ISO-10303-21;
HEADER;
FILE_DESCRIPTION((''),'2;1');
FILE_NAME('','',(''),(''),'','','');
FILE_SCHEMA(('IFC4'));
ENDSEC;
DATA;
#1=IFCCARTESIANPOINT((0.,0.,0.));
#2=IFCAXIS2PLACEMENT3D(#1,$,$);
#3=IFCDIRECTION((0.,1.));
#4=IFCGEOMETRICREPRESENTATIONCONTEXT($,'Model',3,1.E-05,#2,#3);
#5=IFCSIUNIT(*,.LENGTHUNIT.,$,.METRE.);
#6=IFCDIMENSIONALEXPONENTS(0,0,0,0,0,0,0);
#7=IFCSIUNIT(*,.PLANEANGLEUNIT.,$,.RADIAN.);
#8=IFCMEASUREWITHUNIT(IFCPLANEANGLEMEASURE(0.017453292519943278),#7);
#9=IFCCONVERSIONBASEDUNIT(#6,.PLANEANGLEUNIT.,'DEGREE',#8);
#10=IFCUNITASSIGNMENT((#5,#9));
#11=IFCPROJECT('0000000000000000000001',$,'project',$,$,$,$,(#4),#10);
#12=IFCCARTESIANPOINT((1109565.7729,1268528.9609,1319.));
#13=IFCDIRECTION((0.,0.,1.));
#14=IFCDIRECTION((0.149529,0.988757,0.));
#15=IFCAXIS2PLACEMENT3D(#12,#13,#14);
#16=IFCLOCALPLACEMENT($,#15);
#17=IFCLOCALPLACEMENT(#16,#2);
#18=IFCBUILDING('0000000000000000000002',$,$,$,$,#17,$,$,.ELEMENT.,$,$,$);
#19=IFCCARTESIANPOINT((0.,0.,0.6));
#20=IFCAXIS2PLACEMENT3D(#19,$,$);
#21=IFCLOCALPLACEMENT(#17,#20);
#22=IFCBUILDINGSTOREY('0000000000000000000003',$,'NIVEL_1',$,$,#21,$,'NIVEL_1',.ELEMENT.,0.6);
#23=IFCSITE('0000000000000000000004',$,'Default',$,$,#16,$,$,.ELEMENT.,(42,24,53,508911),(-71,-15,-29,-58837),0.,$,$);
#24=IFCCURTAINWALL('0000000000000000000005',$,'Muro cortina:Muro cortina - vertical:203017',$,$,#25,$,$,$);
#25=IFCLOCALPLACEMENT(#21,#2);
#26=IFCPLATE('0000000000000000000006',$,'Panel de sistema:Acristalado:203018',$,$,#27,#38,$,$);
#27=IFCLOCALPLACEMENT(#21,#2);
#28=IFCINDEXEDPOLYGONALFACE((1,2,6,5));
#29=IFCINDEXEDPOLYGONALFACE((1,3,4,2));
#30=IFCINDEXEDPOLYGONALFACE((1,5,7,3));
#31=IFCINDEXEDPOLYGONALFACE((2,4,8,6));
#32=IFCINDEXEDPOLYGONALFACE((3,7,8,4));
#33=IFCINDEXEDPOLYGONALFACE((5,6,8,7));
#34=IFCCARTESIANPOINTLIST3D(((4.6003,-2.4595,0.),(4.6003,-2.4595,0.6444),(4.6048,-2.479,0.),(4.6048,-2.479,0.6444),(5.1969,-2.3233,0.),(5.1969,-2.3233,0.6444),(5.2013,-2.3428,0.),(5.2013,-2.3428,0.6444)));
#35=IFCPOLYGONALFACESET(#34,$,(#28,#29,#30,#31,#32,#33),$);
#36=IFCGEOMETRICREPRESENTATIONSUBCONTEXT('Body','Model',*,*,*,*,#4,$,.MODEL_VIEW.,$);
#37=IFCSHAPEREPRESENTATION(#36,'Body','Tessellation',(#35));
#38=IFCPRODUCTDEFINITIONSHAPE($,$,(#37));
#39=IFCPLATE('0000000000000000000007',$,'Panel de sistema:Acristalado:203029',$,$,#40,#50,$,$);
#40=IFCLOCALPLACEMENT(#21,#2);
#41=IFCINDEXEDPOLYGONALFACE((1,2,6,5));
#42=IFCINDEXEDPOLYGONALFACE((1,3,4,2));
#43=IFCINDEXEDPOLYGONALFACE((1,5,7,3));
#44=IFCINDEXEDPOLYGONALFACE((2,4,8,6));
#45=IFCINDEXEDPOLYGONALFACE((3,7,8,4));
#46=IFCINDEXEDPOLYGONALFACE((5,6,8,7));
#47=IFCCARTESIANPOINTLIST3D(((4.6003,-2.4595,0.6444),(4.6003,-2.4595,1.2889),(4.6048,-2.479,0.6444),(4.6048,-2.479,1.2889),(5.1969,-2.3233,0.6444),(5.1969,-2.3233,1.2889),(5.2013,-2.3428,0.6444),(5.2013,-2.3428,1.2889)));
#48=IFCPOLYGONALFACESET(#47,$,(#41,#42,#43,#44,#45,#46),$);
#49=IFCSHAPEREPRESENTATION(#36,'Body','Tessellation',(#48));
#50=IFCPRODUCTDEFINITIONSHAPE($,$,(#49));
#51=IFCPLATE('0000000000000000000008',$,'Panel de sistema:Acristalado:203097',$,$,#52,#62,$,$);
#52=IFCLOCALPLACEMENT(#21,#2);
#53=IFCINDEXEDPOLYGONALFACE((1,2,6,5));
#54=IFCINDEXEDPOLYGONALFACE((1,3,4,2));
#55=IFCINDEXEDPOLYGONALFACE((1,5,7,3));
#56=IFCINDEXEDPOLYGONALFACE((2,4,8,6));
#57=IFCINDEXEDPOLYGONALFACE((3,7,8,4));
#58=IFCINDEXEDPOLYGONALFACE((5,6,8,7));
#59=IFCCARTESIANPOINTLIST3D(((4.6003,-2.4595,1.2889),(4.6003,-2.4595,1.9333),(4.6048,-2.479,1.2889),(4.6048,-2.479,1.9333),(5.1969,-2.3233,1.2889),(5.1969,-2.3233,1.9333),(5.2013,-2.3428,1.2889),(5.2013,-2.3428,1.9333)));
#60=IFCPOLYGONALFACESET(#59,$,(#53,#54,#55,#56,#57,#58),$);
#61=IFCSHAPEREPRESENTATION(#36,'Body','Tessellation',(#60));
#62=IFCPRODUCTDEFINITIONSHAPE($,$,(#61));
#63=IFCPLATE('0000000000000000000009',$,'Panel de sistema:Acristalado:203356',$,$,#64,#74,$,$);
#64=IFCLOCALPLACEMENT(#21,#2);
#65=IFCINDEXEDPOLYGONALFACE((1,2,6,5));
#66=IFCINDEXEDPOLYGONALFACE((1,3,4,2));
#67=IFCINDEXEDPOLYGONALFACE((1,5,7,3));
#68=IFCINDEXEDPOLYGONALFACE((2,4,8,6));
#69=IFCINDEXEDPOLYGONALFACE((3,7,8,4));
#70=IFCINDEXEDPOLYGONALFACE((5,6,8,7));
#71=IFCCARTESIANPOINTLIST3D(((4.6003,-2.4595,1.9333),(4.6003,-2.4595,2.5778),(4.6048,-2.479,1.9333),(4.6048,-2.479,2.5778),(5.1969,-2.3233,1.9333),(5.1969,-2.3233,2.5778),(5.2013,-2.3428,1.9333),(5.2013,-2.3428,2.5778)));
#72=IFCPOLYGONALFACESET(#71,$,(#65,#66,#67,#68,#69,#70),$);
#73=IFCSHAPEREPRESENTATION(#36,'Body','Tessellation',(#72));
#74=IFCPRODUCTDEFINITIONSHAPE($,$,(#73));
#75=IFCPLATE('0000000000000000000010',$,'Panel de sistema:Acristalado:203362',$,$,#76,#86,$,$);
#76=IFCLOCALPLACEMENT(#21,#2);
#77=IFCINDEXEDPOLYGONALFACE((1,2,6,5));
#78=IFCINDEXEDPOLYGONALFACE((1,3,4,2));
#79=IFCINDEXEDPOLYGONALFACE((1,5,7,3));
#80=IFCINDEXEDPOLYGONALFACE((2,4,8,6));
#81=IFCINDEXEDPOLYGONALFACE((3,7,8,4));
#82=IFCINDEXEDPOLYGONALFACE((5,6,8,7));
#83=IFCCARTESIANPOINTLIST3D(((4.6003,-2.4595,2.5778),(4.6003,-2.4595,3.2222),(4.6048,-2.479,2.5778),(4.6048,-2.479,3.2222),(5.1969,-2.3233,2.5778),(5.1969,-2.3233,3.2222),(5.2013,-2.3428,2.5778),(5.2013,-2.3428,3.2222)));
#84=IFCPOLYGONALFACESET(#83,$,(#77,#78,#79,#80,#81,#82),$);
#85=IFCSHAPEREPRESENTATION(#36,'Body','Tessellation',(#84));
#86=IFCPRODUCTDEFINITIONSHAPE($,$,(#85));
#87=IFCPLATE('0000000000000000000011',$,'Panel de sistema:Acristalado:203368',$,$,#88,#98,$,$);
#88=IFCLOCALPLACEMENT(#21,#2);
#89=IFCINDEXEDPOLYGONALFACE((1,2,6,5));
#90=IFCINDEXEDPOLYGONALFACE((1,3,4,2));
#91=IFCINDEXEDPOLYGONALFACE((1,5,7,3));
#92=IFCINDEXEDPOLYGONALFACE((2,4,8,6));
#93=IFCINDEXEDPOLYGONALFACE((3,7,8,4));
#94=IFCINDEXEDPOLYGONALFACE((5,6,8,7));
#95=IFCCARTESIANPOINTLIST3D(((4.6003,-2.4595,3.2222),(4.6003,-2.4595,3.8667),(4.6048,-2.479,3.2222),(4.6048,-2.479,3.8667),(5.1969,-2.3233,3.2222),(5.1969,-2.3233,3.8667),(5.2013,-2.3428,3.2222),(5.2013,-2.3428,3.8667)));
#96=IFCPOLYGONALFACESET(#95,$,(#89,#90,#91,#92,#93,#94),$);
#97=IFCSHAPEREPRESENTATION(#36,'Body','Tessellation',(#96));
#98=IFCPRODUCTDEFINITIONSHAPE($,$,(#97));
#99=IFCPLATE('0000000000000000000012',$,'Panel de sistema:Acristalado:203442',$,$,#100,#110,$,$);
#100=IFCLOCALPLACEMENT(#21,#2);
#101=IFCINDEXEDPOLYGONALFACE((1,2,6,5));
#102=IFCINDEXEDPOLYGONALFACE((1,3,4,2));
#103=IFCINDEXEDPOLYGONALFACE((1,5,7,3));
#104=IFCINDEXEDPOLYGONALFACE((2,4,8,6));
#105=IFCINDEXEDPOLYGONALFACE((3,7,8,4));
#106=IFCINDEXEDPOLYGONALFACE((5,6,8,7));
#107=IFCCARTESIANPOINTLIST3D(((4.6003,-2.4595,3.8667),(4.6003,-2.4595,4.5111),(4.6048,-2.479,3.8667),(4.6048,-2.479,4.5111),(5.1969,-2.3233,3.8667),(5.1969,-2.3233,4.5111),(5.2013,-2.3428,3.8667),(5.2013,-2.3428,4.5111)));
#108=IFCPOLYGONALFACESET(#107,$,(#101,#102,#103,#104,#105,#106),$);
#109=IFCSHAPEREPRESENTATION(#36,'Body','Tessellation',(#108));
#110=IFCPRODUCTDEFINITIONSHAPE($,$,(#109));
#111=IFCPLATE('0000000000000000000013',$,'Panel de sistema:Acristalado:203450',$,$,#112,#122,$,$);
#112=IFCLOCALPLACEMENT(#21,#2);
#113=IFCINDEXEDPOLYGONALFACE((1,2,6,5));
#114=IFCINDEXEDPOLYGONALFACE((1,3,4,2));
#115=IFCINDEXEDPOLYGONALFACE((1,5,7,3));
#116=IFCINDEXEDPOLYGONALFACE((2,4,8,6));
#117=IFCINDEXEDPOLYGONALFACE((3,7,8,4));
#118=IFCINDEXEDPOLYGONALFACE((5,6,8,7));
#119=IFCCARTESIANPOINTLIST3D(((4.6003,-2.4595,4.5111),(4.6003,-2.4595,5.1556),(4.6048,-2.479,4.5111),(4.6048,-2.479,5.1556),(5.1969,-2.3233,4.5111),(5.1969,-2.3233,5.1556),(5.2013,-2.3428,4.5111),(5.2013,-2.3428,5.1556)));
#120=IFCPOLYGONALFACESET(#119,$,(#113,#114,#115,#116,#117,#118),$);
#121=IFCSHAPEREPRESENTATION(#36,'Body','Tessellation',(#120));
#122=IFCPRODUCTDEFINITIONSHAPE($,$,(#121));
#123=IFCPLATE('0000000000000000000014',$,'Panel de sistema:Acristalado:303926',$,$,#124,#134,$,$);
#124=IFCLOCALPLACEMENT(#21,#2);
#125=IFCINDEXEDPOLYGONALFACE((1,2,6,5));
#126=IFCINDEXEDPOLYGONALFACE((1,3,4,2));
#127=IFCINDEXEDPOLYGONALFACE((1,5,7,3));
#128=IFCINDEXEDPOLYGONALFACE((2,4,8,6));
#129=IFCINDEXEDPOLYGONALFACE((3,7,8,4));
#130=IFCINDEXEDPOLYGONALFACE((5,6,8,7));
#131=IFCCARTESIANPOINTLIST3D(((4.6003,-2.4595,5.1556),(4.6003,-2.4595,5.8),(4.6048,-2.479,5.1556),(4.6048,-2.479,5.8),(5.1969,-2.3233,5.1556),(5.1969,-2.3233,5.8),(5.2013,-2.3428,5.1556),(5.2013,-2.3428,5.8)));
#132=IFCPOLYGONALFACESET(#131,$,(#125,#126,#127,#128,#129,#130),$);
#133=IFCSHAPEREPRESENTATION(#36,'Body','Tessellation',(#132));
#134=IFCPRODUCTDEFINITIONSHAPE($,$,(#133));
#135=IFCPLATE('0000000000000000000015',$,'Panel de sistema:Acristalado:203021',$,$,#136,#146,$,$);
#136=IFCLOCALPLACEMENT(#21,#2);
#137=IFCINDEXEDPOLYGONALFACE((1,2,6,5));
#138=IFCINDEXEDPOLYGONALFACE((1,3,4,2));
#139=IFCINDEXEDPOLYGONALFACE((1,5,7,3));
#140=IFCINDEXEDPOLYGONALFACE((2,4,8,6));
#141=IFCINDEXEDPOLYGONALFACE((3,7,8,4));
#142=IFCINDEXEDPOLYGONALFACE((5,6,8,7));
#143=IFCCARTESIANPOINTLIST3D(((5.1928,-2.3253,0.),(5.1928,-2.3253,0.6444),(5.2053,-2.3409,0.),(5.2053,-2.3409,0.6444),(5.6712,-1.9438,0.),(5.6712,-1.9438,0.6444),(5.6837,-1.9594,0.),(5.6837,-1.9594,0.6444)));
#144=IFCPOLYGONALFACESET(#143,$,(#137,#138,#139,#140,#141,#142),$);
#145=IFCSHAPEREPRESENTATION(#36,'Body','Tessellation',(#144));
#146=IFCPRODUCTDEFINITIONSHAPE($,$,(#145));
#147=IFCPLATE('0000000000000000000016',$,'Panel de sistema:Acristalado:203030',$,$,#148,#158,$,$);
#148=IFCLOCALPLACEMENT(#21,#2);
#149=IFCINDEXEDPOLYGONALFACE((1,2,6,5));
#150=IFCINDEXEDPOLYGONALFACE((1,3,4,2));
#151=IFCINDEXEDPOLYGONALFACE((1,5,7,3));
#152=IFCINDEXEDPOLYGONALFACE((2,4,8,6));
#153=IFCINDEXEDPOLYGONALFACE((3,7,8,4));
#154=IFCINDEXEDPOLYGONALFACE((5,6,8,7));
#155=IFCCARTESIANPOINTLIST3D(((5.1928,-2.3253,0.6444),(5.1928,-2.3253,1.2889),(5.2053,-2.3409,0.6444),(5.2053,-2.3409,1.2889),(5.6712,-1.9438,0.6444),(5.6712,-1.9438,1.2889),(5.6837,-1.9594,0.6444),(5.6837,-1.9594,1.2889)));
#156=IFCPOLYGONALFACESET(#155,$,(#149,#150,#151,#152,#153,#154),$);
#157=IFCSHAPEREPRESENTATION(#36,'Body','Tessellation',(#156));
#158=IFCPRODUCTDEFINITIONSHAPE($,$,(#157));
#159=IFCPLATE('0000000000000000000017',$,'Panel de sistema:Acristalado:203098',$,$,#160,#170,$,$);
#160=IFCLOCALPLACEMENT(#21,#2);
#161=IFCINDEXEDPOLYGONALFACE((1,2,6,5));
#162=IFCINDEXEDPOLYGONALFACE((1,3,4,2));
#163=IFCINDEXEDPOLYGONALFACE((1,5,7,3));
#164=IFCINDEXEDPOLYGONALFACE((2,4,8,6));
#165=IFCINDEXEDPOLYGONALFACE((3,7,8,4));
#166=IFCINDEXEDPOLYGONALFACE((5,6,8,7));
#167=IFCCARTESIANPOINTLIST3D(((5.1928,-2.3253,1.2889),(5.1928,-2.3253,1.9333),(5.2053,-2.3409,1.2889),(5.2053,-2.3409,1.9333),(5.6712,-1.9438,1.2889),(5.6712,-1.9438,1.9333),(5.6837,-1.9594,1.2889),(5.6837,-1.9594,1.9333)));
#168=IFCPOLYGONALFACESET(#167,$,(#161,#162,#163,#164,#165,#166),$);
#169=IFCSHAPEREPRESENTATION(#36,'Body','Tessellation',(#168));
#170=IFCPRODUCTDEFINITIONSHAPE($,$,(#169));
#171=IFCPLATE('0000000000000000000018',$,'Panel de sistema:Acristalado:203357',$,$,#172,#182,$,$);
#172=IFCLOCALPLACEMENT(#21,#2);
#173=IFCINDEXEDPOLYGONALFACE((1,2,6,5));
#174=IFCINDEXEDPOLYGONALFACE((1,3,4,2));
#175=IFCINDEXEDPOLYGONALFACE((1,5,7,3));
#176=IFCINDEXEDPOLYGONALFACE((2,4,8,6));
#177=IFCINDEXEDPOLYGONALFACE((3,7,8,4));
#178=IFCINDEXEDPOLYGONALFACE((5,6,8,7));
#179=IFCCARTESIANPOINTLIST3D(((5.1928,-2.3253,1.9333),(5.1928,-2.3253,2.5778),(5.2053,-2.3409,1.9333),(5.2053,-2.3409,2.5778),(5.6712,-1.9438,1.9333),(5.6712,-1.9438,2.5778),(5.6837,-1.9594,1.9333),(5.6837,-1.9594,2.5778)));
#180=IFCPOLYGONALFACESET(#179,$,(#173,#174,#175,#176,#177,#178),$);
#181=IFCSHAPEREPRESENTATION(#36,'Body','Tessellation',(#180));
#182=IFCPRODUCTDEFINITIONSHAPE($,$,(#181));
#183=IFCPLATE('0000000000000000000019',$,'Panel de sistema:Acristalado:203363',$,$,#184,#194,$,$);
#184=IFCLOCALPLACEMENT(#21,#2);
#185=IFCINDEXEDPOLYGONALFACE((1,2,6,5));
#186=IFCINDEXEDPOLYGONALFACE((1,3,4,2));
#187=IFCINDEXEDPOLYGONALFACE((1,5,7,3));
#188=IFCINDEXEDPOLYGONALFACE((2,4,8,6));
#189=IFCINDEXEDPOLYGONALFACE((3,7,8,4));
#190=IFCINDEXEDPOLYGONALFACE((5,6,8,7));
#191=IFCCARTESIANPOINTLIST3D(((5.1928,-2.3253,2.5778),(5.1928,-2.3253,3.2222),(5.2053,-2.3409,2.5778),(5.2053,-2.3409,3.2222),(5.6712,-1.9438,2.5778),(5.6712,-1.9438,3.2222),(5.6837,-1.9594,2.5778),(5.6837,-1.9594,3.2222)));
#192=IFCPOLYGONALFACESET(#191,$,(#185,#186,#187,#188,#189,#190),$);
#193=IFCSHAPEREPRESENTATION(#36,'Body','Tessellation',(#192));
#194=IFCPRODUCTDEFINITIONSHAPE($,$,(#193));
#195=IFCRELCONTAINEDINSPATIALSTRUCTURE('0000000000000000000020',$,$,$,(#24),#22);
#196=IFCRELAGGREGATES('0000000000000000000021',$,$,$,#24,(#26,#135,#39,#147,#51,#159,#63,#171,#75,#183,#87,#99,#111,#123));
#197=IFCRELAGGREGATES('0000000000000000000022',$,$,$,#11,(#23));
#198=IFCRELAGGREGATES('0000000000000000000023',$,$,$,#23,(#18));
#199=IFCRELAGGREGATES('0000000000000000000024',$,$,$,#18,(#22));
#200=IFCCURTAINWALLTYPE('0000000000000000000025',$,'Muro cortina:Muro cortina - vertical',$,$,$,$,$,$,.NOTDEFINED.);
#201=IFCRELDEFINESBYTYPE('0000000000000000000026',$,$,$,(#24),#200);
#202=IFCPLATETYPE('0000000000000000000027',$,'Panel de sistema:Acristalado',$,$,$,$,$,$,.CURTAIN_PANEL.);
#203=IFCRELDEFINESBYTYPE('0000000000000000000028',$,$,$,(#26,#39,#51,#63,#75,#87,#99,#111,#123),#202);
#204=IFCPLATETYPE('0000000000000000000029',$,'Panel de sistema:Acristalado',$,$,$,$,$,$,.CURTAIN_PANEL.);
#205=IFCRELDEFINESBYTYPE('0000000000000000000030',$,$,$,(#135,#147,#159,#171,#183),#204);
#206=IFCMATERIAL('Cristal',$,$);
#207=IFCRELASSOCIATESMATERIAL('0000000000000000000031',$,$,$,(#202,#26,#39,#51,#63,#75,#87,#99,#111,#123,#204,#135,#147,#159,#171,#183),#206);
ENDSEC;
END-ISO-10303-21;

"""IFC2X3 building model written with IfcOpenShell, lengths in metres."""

from ifc_helpers import new_model, entity, si_unit, converted_unit, direction, frame, frame_2d, origin, place, context, subcontext, project, spatial, rectangle, extrude, source, transform, mapped, material, type_object, type_shapes, element, aggregate, save


model = new_model("IFC2X3")

# Units and contexts
model_context = context("Model", 3, precision=1e-05, world=origin(), true_north=direction((0.0, 1.0)))
body_context = subcontext(model_context, "Body", "Model", "MODEL_VIEW")
ifc_project = project(units=[si_unit("LENGTHUNIT", "METRE"), converted_unit("PLANEANGLEUNIT", "DEGREE", entity("IfcPlaneAngleMeasure", 0.017453292519943278), si_unit("PLANEANGLEUNIT", "RADIAN"), dimensions=[0, 0, 0, 0, 0, 0, 0])], contexts=[model_context])

# Site, building, storey
site_placement = place(None, frame((1109565.7729, 1268528.9609, 1319.0), z_axis=(0.0, 0.0, 1.0), x_axis=(0.149529, 0.988757, 0.0)))
site = spatial("IfcSite", under=ifc_project, at=site_placement, Name="Default", CompositionType="ELEMENT", RefLatitude=(42, 24, 53, 508911), RefLongitude=(-71, -15, -29, -58837), RefElevation=0.0)
building_placement = place(site_placement, origin())
building = spatial("IfcBuilding", under=site, at=building_placement, CompositionType="ELEMENT")
storey_placement = place(building_placement, frame((0.0, 0.0, 0.6)))
storey = spatial("IfcBuildingStorey", under=building, at=storey_placement, Name="NIVEL_1", LongName="NIVEL_1", CompositionType="ELEMENT", Elevation=0.6)

# Curtain wall, plates
curtain_wall_type = type_object("IfcCurtainWallType", Name="Muro cortina:Muro cortina - vertical", PredefinedType="NOTDEFINED")
curtain_wall_1_placement = place(storey_placement, frame((0.0, 0.0, -0.6)))
curtain_wall_1 = element("IfcCurtainWall", 1, at=curtain_wall_1_placement, inside=storey, type_object=curtain_wall_type, Name="Muro cortina:Muro cortina - vertical:203017")
ifc_material_1 = material(Name="Cristal")
plate_type_1 = type_object("IfcPlateType", Name="Panel de sistema:Acristalado", PredefinedType="CURTAIN_PANEL", material=ifc_material_1)
shared_shape_1 = source(origin(), body_context, "Body", "SweptSolid", [
    extrude(rectangle(XDim=0.02, YDim=0.6119, at=frame_2d((0.0, 0.0), x_axis=(1.0, 0.0))), frame((0.0, 0.0, 0.0), z_axis=(0.0, 0.0, 1.0), x_axis=(0.0, 1.0, 0.0)), (0.0, 0.0, 1.0), 0.6444),
])
type_shapes(plate_type_1, [shared_shape_1])
plate_1_placement = place(curtain_wall_1_placement, frame((4.9008, -2.4012, 0.6), z_axis=(0.0, 0.0, 1.0), x_axis=(0.974928, 0.222521, 0.0)))
plate_1 = element("IfcPlate", 2, at=plate_1_placement, type_object=plate_type_1, material=ifc_material_1, Name="Panel de sistema:Acristalado:203018", context=body_context, shape_type="MappedRepresentation", body=[
    mapped(shared_shape_1, transform((0.0, 0.0, 0.0), scale=1.0)),
])
plate_2_placement = place(curtain_wall_1_placement, frame((4.9008, -2.4012, 1.2444), z_axis=(0.0, 0.0, 1.0), x_axis=(0.974928, 0.222521, 0.0)))
plate_2 = element("IfcPlate", 3, at=plate_2_placement, type_object=plate_type_1, material=ifc_material_1, Name="Panel de sistema:Acristalado:203029", context=body_context, shape_type="MappedRepresentation", body=[
    mapped(shared_shape_1, transform((0.0, 0.0, 0.0), scale=1.0)),
])
plate_3_placement = place(curtain_wall_1_placement, frame((4.9008, -2.4012, 1.8889), z_axis=(0.0, 0.0, 1.0), x_axis=(0.974928, 0.222521, 0.0)))
plate_3 = element("IfcPlate", 4, at=plate_3_placement, type_object=plate_type_1, material=ifc_material_1, Name="Panel de sistema:Acristalado:203097", context=body_context, shape_type="MappedRepresentation", body=[
    mapped(shared_shape_1, transform((0.0, 0.0, 0.0), scale=1.0)),
])
plate_4_placement = place(curtain_wall_1_placement, frame((4.9008, -2.4012, 2.5333), z_axis=(0.0, 0.0, 1.0), x_axis=(0.974928, 0.222521, 0.0)))
plate_4 = element("IfcPlate", 5, at=plate_4_placement, type_object=plate_type_1, material=ifc_material_1, Name="Panel de sistema:Acristalado:203356", context=body_context, shape_type="MappedRepresentation", body=[
    mapped(shared_shape_1, transform((0.0, 0.0, 0.0), scale=1.0)),
])
plate_5_placement = place(curtain_wall_1_placement, frame((4.9008, -2.4012, 3.1778), z_axis=(0.0, 0.0, 1.0), x_axis=(0.974928, 0.222521, 0.0)))
plate_5 = element("IfcPlate", 6, at=plate_5_placement, type_object=plate_type_1, material=ifc_material_1, Name="Panel de sistema:Acristalado:203362", context=body_context, shape_type="MappedRepresentation", body=[
    mapped(shared_shape_1, transform((0.0, 0.0, 0.0), scale=1.0)),
])
plate_6_placement = place(curtain_wall_1_placement, frame((4.9008, -2.4012, 3.8222), z_axis=(0.0, 0.0, 1.0), x_axis=(0.974928, 0.222521, 0.0)))
plate_6 = element("IfcPlate", 7, at=plate_6_placement, type_object=plate_type_1, material=ifc_material_1, Name="Panel de sistema:Acristalado:203368", context=body_context, shape_type="MappedRepresentation", body=[
    mapped(shared_shape_1, transform((0.0, 0.0, 0.0), scale=1.0)),
])
plate_7_placement = place(curtain_wall_1_placement, frame((4.9008, -2.4012, 4.4667), z_axis=(0.0, 0.0, 1.0), x_axis=(0.974928, 0.222521, 0.0)))
plate_7 = element("IfcPlate", 8, at=plate_7_placement, type_object=plate_type_1, material=ifc_material_1, Name="Panel de sistema:Acristalado:203442", context=body_context, shape_type="MappedRepresentation", body=[
    mapped(shared_shape_1, transform((0.0, 0.0, 0.0), scale=1.0)),
])
plate_8_placement = place(curtain_wall_1_placement, frame((4.9008, -2.4012, 5.1111), z_axis=(0.0, 0.0, 1.0), x_axis=(0.974928, 0.222521, 0.0)))
plate_8 = element("IfcPlate", 9, at=plate_8_placement, type_object=plate_type_1, material=ifc_material_1, Name="Panel de sistema:Acristalado:203450", context=body_context, shape_type="MappedRepresentation", body=[
    mapped(shared_shape_1, transform((0.0, 0.0, 0.0), scale=1.0)),
])
plate_9_placement = place(curtain_wall_1_placement, frame((4.9008, -2.4012, 5.7556), z_axis=(0.0, 0.0, 1.0), x_axis=(0.974928, 0.222521, 0.0)))
plate_9 = element("IfcPlate", 10, at=plate_9_placement, type_object=plate_type_1, material=ifc_material_1, Name="Panel de sistema:Acristalado:303926", context=body_context, shape_type="MappedRepresentation", body=[
    mapped(shared_shape_1, transform((0.0, 0.0, 0.0), scale=1.0)),
])
plate_type_2 = type_object("IfcPlateType", Name="Panel de sistema:Acristalado", PredefinedType="CURTAIN_PANEL", material=ifc_material_1)
shared_shape_2 = source(origin(), body_context, "Body", "SweptSolid", [
    extrude(rectangle(XDim=0.02, YDim=0.6119, at=frame_2d((0.0, 0.0), x_axis=(1.0, 0.0))), frame((0.0, 0.0, 0.0), z_axis=(0.0, 0.0, 1.0), x_axis=(0.0, 1.0, 0.0)), (0.0, 0.0, 1.0), 0.6444),
])
type_shapes(plate_type_2, [shared_shape_2])
plate_10_placement = place(curtain_wall_1_placement, frame((5.4383, -2.1423, 0.6), z_axis=(0.0, 0.0, 1.0), x_axis=(0.781832, 0.62349, 0.0)))
plate_10 = element("IfcPlate", 11, at=plate_10_placement, type_object=plate_type_2, material=ifc_material_1, Name="Panel de sistema:Acristalado:203021", context=body_context, shape_type="MappedRepresentation", body=[
    mapped(shared_shape_2, transform((0.0, 0.0, 0.0), scale=1.0)),
])
plate_11_placement = place(curtain_wall_1_placement, frame((5.4383, -2.1423, 1.2444), z_axis=(0.0, 0.0, 1.0), x_axis=(0.781832, 0.62349, 0.0)))
plate_11 = element("IfcPlate", 12, at=plate_11_placement, type_object=plate_type_2, material=ifc_material_1, Name="Panel de sistema:Acristalado:203030", context=body_context, shape_type="MappedRepresentation", body=[
    mapped(shared_shape_2, transform((0.0, 0.0, 0.0), scale=1.0)),
])
plate_12_placement = place(curtain_wall_1_placement, frame((5.4383, -2.1423, 1.8889), z_axis=(0.0, 0.0, 1.0), x_axis=(0.781832, 0.62349, 0.0)))
plate_12 = element("IfcPlate", 13, at=plate_12_placement, type_object=plate_type_2, material=ifc_material_1, Name="Panel de sistema:Acristalado:203098", context=body_context, shape_type="MappedRepresentation", body=[
    mapped(shared_shape_2, transform((0.0, 0.0, 0.0), scale=1.0)),
])
plate_13_placement = place(curtain_wall_1_placement, frame((5.4383, -2.1423, 2.5333), z_axis=(0.0, 0.0, 1.0), x_axis=(0.781832, 0.62349, 0.0)))
plate_13 = element("IfcPlate", 14, at=plate_13_placement, type_object=plate_type_2, material=ifc_material_1, Name="Panel de sistema:Acristalado:203357", context=body_context, shape_type="MappedRepresentation", body=[
    mapped(shared_shape_2, transform((0.0, 0.0, 0.0), scale=1.0)),
])
plate_14_placement = place(curtain_wall_1_placement, frame((5.4383, -2.1423, 3.1778), z_axis=(0.0, 0.0, 1.0), x_axis=(0.781832, 0.62349, 0.0)))
plate_14 = element("IfcPlate", 15, at=plate_14_placement, type_object=plate_type_2, material=ifc_material_1, Name="Panel de sistema:Acristalado:203363", context=body_context, shape_type="MappedRepresentation", body=[
    mapped(shared_shape_2, transform((0.0, 0.0, 0.0), scale=1.0)),
])
aggregate(curtain_wall_1, [plate_1, plate_10, plate_2, plate_11, plate_3, plate_12, plate_4, plate_13, plate_5, plate_14, plate_6, plate_7, plate_8, plate_9])

save(model, "model.ifc")
